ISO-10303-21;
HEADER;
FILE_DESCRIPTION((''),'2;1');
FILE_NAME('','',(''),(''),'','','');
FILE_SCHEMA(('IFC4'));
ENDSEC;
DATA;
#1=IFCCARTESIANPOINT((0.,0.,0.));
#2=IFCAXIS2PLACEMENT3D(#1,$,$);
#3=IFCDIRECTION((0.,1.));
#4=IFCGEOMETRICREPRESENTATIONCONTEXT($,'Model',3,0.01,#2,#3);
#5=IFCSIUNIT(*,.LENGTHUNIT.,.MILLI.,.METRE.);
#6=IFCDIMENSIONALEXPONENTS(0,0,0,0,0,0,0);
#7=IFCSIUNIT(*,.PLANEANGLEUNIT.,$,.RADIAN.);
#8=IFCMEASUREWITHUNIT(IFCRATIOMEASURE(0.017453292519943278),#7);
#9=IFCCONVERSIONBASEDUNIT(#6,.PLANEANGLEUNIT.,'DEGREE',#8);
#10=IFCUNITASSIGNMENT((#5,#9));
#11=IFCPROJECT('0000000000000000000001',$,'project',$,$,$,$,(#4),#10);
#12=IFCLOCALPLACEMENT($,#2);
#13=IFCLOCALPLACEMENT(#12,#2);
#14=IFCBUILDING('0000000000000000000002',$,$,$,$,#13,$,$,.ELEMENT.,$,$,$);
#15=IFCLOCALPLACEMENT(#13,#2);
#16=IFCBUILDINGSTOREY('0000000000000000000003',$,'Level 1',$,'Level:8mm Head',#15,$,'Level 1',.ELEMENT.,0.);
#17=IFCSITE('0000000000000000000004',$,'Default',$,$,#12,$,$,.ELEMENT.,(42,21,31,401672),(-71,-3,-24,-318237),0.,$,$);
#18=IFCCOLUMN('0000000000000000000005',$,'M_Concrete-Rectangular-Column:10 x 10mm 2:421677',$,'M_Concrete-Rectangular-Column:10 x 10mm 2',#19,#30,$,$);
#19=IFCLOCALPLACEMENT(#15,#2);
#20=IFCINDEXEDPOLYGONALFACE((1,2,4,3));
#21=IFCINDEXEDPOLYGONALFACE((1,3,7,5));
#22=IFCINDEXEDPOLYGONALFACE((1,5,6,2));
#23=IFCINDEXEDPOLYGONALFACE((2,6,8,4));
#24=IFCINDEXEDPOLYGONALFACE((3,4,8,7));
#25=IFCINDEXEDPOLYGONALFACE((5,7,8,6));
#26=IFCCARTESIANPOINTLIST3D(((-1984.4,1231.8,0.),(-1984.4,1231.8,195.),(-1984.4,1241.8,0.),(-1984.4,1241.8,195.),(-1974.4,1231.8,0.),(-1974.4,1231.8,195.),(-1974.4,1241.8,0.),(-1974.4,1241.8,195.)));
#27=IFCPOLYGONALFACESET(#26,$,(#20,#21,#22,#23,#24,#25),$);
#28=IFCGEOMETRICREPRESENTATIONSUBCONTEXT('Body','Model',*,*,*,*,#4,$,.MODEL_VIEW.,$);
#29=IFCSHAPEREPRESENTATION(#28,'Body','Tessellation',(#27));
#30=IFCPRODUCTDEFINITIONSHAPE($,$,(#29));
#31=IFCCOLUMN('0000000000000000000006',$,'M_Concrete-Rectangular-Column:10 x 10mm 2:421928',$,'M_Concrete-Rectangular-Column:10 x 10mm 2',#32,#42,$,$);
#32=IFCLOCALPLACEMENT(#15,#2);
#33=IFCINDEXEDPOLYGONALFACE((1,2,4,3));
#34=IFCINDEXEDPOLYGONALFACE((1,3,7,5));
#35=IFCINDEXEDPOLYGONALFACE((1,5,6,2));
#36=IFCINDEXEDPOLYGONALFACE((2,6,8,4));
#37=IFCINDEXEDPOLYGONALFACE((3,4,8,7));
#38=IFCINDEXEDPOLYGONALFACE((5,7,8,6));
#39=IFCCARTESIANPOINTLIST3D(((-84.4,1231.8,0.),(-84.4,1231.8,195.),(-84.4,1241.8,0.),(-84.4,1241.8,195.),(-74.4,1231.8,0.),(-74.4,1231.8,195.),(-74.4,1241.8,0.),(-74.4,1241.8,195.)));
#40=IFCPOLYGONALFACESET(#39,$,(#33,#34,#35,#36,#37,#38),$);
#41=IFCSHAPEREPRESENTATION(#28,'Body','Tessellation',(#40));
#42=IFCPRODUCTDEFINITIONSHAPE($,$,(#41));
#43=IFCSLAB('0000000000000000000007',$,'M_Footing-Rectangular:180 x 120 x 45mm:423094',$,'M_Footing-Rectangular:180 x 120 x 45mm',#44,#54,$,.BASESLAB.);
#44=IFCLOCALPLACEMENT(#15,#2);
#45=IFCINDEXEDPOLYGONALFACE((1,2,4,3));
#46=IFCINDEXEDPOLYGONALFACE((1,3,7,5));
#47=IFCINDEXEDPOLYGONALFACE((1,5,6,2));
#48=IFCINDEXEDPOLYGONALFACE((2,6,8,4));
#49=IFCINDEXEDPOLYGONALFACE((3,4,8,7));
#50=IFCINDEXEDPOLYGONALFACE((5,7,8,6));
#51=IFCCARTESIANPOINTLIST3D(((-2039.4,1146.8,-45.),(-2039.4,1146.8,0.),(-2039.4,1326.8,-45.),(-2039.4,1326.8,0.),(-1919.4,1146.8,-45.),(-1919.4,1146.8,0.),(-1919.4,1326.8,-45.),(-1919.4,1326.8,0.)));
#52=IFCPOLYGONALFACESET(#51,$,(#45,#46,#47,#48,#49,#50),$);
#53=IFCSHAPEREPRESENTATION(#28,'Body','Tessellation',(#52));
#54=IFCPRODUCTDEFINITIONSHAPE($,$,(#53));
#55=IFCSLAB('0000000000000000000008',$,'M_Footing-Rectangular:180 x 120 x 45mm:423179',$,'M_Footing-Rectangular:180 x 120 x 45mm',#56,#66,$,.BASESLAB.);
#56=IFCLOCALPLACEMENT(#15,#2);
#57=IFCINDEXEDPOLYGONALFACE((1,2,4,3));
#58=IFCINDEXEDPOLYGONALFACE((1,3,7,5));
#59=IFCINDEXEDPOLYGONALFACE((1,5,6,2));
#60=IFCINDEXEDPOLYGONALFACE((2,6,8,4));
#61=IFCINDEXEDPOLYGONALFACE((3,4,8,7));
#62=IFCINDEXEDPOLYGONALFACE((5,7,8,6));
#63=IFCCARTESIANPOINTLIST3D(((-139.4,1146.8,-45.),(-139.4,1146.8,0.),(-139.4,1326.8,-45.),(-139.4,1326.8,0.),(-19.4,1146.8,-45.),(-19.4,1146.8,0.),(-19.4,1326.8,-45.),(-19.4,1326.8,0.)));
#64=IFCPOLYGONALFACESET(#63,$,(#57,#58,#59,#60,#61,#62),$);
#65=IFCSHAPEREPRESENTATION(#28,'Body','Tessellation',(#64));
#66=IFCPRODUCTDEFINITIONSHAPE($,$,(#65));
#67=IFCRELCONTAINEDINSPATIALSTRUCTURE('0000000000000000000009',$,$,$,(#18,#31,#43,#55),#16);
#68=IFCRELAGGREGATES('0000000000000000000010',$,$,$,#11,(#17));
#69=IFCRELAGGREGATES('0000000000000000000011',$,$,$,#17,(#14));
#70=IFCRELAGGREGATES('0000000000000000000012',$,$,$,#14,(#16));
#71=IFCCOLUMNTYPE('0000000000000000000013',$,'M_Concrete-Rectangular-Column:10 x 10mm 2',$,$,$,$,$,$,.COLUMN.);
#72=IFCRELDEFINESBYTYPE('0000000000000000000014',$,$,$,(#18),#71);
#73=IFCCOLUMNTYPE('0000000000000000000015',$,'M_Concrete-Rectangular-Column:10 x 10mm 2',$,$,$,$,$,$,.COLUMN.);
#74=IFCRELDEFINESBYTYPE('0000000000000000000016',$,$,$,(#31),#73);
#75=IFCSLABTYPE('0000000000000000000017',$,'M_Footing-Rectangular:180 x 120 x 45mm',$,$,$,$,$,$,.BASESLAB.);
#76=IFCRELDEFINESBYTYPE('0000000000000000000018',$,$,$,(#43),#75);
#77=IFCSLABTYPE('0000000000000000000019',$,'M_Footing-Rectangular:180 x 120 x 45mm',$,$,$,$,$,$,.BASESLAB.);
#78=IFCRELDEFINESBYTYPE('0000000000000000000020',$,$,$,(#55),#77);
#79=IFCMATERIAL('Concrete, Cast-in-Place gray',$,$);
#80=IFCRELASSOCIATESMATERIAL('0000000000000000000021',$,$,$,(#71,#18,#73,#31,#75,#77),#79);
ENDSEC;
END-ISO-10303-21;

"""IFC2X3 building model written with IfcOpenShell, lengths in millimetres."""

from ifc_helpers import new_model, entity, si_unit, converted_unit, direction, frame, frame_2d, origin, origin_2d_with_axis, place, context, subcontext, project, spatial, rectangle, extrude, source, transform, mapped, material, type_object, type_shapes, element, save


model = new_model("IFC2X3")

# Units and contexts
model_context = context("Model", 3, precision=0.01, world=origin(), true_north=direction((0.0, 1.0)))
body_context = subcontext(model_context, "Body", "Model", "MODEL_VIEW")
ifc_project = project(units=[si_unit("LENGTHUNIT", "METRE", prefix="MILLI"), converted_unit("PLANEANGLEUNIT", "DEGREE", entity("IfcRatioMeasure", 0.017453292519943278), si_unit("PLANEANGLEUNIT", "RADIAN"), dimensions=[0, 0, 0, 0, 0, 0, 0])], contexts=[model_context])

# Site, building, storey
site_placement = place(None, origin())
site = spatial("IfcSite", under=ifc_project, at=site_placement, Name="Default", CompositionType="ELEMENT", RefLatitude=(42, 21, 31, 401672), RefLongitude=(-71, -3, -24, -318237), RefElevation=0.0)
building_placement = place(site_placement, origin())
building = spatial("IfcBuilding", under=site, at=building_placement, CompositionType="ELEMENT")
storey_placement = place(building_placement, origin())
storey = spatial("IfcBuildingStorey", under=building, at=storey_placement, Name="Level 1", ObjectType="Level:8mm Head", LongName="Level 1", CompositionType="ELEMENT", Elevation=0.0)

# Columns
ifc_material = material(Name="Concrete, Cast-in-Place gray")
column_type_1 = type_object("IfcColumnType", Name="M_Concrete-Rectangular-Column:10 x 10mm 2", PredefinedType="COLUMN", material=ifc_material)
shared_shape_1 = source(origin(), body_context, "Body", "SweptSolid", [
    extrude(rectangle(XDim=10.0, YDim=10.0, at=frame_2d((0.0, 0.0), x_axis=(1.0, 0.0))), frame((-1979.4, 1236.8, 0.0), z_axis=(0.0, 0.0, 1.0), x_axis=(0.0, -1.0, 0.0)), (0.0, 0.0, 1.0), 195.0),
])
type_shapes(column_type_1, [shared_shape_1])
column_1_placement = place(storey_placement, origin())
element("IfcColumn", 1, at=column_1_placement, inside=storey, type_object=column_type_1, material=ifc_material, Name="M_Concrete-Rectangular-Column:10 x 10mm 2:421677", ObjectType="M_Concrete-Rectangular-Column:10 x 10mm 2", context=body_context, shape_type="MappedRepresentation", body=[
    mapped(shared_shape_1, transform((0.0, 0.0, 0.0), scale=1.0)),
])
column_type_2 = type_object("IfcColumnType", Name="M_Concrete-Rectangular-Column:10 x 10mm 2", PredefinedType="COLUMN", material=ifc_material)
shared_shape_2 = source(origin(), body_context, "Body", "SweptSolid", [
    extrude(rectangle(XDim=10.0, YDim=10.0, at=origin_2d_with_axis()), frame((-79.4, 1236.8, 0.0), z_axis=(0.0, 0.0, 1.0), x_axis=(0.0, -1.0, 0.0)), (0.0, 0.0, 1.0), 195.0),
])
type_shapes(column_type_2, [shared_shape_2])
column_2_placement = place(storey_placement, origin())
element("IfcColumn", 2, at=column_2_placement, inside=storey, type_object=column_type_2, material=ifc_material, Name="M_Concrete-Rectangular-Column:10 x 10mm 2:421928", ObjectType="M_Concrete-Rectangular-Column:10 x 10mm 2", context=body_context, shape_type="MappedRepresentation", body=[
    mapped(shared_shape_2, transform((0.0, 0.0, 0.0), scale=1.0)),
])

# Slabs
slab_type_1 = type_object("IfcSlabType", Name="M_Footing-Rectangular:180 x 120 x 45mm", PredefinedType="BASESLAB", material=ifc_material)
slab_1_placement = place(storey_placement, origin())
element("IfcSlab", 3, at=slab_1_placement, inside=storey, type_object=slab_type_1, Name="M_Footing-Rectangular:180 x 120 x 45mm:423094", ObjectType="M_Footing-Rectangular:180 x 120 x 45mm", PredefinedType="BASESLAB", context=body_context, shape_type="SweptSolid", body=[
    extrude(rectangle(XDim=120.0, YDim=180.0, at=frame_2d((0.0, 0.0), x_axis=(1.0, 0.0))), frame((-1979.4, 1236.8, -45.0), z_axis=(0.0, 0.0, 1.0), x_axis=(-1.0, 0.0, 0.0)), (0.0, 0.0, 1.0), 45.0),
])
slab_type_2 = type_object("IfcSlabType", Name="M_Footing-Rectangular:180 x 120 x 45mm", PredefinedType="BASESLAB", material=ifc_material)
slab_2_placement = place(storey_placement, origin())
element("IfcSlab", 4, at=slab_2_placement, inside=storey, type_object=slab_type_2, Name="M_Footing-Rectangular:180 x 120 x 45mm:423179", ObjectType="M_Footing-Rectangular:180 x 120 x 45mm", PredefinedType="BASESLAB", context=body_context, shape_type="SweptSolid", body=[
    extrude(rectangle(XDim=120.0, YDim=180.0, at=frame_2d((0.0, 0.0), x_axis=(1.0, 0.0))), frame((-79.4, 1236.8, -45.0), z_axis=(0.0, 0.0, 1.0), x_axis=(-1.0, 0.0, 0.0)), (0.0, 0.0, 1.0), 45.0),
])

save(model, "model.ifc")
